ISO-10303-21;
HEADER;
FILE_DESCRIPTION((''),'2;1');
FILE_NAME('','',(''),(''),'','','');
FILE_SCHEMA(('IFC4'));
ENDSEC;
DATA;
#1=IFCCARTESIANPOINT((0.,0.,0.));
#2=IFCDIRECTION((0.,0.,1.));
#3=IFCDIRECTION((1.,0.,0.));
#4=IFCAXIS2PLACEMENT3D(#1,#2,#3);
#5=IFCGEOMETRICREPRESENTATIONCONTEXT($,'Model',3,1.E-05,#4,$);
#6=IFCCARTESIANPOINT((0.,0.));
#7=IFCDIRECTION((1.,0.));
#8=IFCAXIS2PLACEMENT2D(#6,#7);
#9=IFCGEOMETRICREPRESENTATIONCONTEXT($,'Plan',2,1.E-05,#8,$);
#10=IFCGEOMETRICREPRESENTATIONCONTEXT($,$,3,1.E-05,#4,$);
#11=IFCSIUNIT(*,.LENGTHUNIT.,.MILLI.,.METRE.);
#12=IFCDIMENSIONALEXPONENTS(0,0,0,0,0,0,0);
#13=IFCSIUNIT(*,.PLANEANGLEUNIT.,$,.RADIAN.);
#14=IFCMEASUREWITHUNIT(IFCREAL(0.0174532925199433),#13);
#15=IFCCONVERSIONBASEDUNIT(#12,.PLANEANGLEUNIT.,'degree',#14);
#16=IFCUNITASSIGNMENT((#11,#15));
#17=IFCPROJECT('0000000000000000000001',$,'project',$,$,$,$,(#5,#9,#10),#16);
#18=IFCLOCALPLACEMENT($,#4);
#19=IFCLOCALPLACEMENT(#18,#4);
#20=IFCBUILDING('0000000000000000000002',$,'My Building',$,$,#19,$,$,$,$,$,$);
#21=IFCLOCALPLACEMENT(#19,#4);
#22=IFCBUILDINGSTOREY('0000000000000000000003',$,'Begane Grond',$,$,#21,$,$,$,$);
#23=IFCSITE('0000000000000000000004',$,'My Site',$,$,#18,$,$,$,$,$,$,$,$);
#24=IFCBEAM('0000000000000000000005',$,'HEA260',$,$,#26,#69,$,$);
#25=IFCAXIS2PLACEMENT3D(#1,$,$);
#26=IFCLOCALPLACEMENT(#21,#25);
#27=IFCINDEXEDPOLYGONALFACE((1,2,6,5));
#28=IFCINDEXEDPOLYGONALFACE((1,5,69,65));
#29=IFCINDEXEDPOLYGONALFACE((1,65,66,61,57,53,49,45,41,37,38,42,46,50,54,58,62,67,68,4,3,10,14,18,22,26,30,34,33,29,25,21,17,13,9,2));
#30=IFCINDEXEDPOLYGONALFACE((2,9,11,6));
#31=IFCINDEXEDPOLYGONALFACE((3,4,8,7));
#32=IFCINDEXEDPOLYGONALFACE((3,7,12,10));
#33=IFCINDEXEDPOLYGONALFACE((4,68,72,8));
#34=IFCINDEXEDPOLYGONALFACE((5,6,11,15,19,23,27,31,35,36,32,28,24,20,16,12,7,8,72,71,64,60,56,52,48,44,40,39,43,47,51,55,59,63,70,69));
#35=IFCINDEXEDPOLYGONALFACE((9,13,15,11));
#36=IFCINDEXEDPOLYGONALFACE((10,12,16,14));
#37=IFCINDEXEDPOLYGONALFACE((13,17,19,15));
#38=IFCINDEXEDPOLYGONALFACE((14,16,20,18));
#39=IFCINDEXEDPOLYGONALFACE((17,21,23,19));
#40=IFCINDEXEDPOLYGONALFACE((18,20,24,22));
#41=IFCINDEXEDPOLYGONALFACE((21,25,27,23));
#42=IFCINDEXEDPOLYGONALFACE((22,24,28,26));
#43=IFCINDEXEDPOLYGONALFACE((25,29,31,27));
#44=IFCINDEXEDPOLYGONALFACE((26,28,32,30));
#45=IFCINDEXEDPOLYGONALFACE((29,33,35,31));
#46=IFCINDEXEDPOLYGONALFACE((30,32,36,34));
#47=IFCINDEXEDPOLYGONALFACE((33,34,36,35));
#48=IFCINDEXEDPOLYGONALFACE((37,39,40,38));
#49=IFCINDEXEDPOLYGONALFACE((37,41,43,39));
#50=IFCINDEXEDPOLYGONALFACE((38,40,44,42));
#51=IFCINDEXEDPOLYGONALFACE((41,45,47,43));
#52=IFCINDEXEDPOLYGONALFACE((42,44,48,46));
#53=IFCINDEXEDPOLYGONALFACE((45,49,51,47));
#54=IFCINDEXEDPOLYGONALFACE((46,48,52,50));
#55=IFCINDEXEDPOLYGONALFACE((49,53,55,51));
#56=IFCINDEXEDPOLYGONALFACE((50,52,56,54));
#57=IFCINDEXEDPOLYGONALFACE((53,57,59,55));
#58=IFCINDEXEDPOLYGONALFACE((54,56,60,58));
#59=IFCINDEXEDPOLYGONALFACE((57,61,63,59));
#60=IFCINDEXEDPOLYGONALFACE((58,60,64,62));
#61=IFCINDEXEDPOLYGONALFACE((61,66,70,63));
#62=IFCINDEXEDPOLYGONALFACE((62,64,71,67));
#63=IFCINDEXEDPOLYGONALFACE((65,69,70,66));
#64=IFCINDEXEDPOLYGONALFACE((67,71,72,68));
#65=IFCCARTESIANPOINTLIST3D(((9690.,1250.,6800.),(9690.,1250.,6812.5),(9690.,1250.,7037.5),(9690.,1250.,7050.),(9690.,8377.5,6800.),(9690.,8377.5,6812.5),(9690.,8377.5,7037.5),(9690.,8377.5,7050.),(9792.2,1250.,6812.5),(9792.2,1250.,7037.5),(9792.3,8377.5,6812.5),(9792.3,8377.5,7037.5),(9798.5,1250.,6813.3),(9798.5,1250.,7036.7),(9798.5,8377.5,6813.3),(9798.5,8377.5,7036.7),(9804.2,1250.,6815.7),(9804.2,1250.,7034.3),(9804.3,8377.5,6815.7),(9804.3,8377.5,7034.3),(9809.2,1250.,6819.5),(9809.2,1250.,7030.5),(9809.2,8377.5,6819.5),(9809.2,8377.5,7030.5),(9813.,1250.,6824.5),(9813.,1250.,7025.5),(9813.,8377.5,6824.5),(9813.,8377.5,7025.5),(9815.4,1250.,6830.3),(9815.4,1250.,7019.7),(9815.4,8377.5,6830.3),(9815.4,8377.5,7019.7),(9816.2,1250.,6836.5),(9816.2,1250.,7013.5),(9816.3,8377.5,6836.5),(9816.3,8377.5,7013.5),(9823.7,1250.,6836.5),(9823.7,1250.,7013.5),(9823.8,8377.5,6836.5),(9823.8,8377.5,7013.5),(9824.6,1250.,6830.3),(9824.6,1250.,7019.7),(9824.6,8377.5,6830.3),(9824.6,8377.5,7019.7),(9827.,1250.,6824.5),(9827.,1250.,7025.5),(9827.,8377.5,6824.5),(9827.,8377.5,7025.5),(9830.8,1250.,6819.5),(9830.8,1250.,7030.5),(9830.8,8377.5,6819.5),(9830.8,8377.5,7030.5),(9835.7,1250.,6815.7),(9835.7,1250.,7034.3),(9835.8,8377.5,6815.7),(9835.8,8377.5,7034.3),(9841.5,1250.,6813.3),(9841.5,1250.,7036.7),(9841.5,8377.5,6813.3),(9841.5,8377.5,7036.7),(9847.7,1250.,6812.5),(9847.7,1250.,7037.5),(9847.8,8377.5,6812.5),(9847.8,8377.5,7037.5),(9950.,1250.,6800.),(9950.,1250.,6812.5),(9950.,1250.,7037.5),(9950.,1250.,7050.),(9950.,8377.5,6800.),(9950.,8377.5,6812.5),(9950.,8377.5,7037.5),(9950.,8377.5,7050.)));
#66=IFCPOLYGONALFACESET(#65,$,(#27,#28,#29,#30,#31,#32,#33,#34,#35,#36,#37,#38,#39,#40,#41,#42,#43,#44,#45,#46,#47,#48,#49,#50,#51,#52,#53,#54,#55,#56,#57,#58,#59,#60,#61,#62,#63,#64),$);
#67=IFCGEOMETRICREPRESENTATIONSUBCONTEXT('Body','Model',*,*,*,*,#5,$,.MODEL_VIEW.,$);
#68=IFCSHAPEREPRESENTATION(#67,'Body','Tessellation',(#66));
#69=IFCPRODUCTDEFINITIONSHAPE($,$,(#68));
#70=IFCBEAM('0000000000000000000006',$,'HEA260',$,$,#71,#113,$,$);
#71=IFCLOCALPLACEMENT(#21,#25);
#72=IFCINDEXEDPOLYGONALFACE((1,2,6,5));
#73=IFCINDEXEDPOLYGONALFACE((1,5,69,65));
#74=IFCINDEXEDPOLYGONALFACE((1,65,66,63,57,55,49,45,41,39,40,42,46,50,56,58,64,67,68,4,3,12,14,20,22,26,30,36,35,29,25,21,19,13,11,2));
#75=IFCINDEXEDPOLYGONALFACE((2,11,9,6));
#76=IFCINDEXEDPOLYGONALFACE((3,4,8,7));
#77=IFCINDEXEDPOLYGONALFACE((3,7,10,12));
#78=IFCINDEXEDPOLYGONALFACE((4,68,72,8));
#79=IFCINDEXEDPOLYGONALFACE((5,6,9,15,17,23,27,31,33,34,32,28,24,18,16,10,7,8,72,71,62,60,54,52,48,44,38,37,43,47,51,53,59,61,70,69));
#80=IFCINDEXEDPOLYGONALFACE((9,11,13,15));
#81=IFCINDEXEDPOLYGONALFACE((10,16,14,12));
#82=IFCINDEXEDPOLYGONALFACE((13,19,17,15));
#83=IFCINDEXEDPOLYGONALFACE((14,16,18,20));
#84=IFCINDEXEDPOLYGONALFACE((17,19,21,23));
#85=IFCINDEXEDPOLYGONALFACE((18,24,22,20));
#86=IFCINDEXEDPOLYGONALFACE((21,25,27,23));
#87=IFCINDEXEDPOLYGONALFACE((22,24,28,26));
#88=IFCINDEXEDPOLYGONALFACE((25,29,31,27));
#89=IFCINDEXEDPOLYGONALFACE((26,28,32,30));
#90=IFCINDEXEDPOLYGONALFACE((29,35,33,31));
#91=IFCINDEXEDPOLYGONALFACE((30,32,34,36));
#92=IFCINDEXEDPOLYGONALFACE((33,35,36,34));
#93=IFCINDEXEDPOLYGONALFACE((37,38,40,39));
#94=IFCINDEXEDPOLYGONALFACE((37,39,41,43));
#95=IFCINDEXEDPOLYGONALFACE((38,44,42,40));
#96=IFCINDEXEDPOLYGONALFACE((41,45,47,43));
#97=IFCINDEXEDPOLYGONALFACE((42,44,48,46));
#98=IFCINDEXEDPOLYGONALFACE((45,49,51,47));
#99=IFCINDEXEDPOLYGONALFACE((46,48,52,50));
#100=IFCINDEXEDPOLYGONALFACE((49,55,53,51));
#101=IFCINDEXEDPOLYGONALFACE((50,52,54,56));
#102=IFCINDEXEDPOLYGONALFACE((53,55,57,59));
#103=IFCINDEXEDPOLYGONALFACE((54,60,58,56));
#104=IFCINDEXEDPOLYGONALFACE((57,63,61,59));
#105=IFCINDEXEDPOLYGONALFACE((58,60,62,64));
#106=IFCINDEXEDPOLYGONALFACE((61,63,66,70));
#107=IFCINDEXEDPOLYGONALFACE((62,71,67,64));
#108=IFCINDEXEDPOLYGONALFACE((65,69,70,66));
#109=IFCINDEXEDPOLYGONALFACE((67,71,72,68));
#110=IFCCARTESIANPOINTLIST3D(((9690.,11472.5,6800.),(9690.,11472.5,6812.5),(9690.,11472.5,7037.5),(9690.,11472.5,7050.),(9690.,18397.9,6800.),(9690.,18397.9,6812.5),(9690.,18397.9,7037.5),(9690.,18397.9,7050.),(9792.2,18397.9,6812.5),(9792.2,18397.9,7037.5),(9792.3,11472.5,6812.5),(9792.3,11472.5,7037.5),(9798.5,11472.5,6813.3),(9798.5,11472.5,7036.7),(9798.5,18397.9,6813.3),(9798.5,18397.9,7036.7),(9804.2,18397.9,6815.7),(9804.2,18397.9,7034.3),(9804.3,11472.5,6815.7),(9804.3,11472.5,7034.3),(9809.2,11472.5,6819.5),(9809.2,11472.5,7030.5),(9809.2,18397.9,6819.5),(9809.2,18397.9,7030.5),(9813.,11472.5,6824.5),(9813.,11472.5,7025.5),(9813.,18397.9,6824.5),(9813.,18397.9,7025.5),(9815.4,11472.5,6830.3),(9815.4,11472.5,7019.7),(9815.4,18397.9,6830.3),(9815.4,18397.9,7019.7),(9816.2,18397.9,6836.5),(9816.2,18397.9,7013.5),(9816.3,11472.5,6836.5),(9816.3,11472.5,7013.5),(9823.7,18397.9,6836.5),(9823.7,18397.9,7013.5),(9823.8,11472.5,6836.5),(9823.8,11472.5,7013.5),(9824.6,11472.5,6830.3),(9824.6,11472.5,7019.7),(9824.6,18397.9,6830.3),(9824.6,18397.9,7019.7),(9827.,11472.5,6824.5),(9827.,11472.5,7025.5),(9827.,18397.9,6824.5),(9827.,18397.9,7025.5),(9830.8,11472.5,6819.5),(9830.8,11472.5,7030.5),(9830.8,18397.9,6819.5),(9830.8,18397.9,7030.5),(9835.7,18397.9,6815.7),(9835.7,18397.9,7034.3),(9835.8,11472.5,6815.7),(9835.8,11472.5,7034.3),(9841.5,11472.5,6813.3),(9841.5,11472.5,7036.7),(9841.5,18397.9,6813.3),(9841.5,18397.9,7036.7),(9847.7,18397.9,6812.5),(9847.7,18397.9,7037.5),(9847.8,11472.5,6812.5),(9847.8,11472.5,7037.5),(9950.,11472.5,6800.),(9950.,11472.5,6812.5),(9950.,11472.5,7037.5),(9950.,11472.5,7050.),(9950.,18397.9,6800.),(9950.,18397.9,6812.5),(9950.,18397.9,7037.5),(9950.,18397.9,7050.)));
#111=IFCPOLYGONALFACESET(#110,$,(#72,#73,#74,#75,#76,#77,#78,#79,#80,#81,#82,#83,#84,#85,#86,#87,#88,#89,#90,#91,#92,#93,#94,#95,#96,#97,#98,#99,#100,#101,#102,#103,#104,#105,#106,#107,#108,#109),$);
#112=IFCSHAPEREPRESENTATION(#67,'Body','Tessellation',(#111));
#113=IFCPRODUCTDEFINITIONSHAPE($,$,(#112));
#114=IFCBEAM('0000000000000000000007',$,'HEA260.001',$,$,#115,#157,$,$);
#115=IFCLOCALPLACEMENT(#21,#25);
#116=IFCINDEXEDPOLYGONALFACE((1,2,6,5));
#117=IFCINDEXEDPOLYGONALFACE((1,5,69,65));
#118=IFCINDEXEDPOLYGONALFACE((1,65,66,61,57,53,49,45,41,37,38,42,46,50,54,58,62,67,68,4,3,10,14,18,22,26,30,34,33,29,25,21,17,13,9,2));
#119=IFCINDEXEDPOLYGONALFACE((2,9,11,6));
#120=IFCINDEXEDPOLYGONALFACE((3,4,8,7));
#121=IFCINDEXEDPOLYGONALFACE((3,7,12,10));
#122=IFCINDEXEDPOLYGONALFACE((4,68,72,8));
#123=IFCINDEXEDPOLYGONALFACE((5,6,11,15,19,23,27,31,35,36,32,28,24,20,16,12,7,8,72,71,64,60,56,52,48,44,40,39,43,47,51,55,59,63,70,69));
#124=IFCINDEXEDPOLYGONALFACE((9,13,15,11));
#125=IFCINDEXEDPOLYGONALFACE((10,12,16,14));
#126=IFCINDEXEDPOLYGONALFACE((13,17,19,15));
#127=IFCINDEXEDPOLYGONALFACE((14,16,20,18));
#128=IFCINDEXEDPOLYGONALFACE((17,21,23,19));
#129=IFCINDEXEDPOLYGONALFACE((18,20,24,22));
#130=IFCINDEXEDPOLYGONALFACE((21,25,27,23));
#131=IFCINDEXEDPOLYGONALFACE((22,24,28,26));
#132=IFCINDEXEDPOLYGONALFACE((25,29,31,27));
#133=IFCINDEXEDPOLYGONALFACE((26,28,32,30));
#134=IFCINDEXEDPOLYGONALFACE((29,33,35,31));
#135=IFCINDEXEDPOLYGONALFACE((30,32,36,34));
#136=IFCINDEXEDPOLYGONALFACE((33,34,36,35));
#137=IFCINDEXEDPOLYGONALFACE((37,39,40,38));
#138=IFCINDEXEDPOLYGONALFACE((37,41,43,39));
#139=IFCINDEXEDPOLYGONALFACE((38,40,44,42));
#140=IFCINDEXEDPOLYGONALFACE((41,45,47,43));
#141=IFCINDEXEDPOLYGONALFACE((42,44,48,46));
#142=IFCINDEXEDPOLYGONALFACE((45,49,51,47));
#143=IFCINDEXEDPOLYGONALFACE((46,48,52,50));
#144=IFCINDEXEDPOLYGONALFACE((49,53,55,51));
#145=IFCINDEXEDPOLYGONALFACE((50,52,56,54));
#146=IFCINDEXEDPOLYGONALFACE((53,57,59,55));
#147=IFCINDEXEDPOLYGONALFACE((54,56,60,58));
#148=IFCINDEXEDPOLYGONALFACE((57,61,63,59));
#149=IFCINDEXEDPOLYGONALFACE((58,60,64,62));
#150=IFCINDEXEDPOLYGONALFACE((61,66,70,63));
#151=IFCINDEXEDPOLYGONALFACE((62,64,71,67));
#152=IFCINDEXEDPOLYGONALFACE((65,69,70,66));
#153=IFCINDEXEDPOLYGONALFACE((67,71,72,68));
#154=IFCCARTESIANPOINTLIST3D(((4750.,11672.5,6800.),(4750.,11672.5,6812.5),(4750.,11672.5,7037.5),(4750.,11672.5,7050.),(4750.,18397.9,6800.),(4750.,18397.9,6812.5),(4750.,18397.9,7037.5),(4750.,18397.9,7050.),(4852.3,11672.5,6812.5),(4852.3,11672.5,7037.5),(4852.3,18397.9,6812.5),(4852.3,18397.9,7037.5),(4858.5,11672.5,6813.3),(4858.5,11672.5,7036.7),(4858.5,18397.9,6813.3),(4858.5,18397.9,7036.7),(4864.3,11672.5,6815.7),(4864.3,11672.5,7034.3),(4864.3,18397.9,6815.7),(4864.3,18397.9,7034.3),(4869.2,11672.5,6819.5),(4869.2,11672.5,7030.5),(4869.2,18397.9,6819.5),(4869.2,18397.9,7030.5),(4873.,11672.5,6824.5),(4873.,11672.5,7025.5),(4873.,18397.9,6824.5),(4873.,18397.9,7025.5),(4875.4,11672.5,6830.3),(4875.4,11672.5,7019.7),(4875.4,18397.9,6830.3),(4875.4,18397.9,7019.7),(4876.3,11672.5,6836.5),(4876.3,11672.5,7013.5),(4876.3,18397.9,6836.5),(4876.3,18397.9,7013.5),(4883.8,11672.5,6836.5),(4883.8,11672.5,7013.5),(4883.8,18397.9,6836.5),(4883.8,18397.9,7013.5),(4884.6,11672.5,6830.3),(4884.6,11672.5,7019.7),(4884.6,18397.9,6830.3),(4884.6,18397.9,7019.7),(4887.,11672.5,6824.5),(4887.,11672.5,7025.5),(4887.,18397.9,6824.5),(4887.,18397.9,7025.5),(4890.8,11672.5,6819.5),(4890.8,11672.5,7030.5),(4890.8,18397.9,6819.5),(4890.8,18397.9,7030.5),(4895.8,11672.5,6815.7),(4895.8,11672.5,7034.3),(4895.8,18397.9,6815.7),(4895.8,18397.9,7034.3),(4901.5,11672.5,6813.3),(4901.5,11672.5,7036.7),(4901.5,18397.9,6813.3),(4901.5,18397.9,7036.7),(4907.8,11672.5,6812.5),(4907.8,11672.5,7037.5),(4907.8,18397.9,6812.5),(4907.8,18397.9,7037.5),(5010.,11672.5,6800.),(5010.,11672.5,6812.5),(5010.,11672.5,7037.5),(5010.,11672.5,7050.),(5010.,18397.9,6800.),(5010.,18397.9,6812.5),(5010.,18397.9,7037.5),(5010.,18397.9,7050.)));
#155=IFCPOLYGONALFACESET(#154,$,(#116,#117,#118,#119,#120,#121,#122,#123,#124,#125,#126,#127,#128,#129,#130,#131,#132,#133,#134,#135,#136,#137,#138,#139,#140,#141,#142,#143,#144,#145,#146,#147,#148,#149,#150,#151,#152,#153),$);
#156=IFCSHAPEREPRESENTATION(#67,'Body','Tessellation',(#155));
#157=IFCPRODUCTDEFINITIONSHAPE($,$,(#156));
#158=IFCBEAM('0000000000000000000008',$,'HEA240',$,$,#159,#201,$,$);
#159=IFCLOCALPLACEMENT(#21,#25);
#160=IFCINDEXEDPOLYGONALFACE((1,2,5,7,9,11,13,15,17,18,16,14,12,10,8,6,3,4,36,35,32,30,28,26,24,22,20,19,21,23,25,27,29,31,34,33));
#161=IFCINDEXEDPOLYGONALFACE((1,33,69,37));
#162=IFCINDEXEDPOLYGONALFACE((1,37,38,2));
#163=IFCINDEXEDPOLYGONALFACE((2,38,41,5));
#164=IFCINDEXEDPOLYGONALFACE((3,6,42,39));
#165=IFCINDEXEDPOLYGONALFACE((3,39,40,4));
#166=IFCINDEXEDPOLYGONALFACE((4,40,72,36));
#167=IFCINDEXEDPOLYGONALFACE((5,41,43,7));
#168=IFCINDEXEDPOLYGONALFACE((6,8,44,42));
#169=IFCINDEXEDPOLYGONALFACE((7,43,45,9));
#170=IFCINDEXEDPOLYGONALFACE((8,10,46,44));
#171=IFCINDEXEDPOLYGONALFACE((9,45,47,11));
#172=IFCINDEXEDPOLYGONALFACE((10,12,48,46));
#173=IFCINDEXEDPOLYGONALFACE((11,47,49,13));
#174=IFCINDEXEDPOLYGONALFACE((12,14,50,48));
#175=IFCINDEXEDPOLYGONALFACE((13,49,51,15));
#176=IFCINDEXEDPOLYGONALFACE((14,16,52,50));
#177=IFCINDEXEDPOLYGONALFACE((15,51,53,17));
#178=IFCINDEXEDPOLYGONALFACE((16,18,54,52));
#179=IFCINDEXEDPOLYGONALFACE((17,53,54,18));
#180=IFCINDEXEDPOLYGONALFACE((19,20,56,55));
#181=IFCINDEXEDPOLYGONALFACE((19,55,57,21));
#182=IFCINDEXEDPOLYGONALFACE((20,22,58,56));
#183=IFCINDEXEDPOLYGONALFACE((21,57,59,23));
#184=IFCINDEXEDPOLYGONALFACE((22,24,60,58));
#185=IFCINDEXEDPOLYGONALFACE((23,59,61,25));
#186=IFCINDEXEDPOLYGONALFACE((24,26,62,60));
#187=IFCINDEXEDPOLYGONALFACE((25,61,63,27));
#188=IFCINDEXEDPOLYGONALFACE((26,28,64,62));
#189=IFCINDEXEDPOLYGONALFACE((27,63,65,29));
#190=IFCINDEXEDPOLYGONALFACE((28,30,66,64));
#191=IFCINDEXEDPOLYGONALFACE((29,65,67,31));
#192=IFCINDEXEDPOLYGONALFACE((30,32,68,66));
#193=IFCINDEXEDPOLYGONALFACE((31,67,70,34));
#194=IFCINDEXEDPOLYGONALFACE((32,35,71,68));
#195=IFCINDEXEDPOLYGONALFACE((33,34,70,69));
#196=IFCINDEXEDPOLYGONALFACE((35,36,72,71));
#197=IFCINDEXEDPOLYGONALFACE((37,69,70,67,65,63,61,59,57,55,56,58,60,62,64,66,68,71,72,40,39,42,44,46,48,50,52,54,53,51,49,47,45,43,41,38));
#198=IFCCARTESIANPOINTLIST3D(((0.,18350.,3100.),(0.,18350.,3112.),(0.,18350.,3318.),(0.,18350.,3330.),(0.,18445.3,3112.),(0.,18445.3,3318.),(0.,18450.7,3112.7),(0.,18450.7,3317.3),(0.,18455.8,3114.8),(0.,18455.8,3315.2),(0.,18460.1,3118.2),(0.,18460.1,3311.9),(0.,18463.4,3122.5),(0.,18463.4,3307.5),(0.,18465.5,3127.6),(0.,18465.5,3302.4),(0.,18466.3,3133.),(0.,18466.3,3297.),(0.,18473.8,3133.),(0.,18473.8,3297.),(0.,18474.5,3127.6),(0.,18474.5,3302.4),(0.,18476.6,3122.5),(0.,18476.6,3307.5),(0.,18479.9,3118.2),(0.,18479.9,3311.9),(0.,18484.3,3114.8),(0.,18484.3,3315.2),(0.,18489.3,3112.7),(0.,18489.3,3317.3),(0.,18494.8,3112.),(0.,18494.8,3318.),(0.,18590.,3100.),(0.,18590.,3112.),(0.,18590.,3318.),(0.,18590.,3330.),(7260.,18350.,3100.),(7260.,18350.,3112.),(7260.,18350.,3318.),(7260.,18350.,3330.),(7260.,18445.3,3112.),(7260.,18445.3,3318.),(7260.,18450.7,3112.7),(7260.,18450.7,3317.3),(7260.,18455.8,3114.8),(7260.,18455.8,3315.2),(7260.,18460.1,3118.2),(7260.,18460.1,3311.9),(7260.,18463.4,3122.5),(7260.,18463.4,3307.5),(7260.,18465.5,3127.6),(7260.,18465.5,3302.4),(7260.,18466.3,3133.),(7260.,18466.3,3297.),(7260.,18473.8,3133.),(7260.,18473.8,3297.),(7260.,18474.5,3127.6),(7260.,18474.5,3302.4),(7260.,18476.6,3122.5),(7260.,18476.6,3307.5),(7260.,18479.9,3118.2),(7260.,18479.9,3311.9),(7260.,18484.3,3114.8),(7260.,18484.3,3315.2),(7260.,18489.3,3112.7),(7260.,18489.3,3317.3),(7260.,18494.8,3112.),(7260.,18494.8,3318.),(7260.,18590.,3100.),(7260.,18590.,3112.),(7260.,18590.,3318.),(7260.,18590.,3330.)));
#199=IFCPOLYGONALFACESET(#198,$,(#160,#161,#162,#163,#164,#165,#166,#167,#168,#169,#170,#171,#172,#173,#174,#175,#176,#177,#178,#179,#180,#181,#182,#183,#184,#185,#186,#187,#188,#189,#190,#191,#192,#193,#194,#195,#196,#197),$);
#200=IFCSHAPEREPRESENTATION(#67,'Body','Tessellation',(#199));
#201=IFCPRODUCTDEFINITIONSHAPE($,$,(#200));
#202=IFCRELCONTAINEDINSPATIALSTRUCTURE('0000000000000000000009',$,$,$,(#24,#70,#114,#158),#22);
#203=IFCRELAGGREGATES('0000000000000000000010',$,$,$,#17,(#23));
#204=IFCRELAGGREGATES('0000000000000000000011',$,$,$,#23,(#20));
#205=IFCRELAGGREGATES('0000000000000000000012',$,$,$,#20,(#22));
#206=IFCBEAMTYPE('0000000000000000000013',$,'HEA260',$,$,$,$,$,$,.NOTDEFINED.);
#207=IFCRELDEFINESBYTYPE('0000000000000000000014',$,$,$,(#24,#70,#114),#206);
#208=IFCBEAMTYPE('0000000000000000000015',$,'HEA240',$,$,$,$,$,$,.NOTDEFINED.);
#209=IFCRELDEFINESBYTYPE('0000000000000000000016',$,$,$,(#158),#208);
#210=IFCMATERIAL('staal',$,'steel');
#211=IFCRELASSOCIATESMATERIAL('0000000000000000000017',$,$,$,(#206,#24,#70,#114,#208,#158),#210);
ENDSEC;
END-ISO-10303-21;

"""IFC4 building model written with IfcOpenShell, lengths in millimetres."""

from ifc_helpers import new_model, entity, si_unit, converted_unit, frame, origin_with_axes, origin_2d_with_axis, place, context, subcontext, project, spatial, i_section, extrude, material, material_profile, profile_set, profile_usage, type_object, element, save


model = new_model("IFC4")

# Units and contexts
model_context = context("Model", 3, precision=1e-05, world=origin_with_axes())
plan_context = context("Plan", 2, precision=1e-05, world=origin_2d_with_axis())
context_of_model = context(None, 3, precision=1e-05, world=origin_with_axes())
body_context = subcontext(model_context, "Body", "Model", "MODEL_VIEW")
ifc_project = project(units=[si_unit("LENGTHUNIT", "METRE", prefix="MILLI"), converted_unit("PLANEANGLEUNIT", "degree", entity("IfcReal", 0.0174532925199433), si_unit("PLANEANGLEUNIT", "RADIAN"), dimensions=[0, 0, 0, 0, 0, 0, 0])], contexts=[model_context, plan_context, context_of_model])

# Site, building, storey
site_placement = place(None, origin_with_axes())
site = spatial("IfcSite", under=ifc_project, at=site_placement, Name="My Site")
building_placement = place(site_placement, origin_with_axes())
building = spatial("IfcBuilding", under=site, at=building_placement, Name="My Building")
storey_placement = place(building_placement, origin_with_axes())
storey = spatial("IfcBuildingStorey", under=building, at=storey_placement, Name="Begane Grond")

# Shared definitions
ifc_material = material(Name="staal", Category="steel")

# Beams
ifc_material_profile_1 = material_profile(ifc_material, i_section(OverallWidth=260.0, OverallDepth=250.0, WebThickness=7.5, FlangeThickness=12.5, FilletRadius=24.0))
ifc_profile_set_1 = profile_set([ifc_material_profile_1], Name="HEA260")
beam_type_1 = type_object("IfcBeamType", Name="HEA260", PredefinedType="NOTDEFINED", material=ifc_profile_set_1)
ifc_profile_usage_1 = profile_usage(ifc_profile_set_1)
beam_1_placement = place(storey_placement, frame((9820.0, 1250.0, 6925.0), z_axis=(0.0, 1.0, 0.0), x_axis=(-1.0, 0.0, 0.0)))
element("IfcBeam", 1, at=beam_1_placement, inside=storey, type_object=beam_type_1, material=ifc_profile_usage_1, Name="HEA260", context=body_context, shape_type="SweptSolid", body=[
    extrude(i_section(OverallWidth=260.0, OverallDepth=250.0, WebThickness=7.5, FlangeThickness=12.5, FilletRadius=24.0), origin_with_axes(), (0.0, 0.0, 1.0), 7127.5),
])
ifc_profile_usage_2 = profile_usage(ifc_profile_set_1)
beam_2_placement = place(storey_placement, frame((9820.0, 18397.9, 6925.0), z_axis=(0.0, -1.0, 0.0), x_axis=(1.0, 0.0, 0.0)))
element("IfcBeam", 2, at=beam_2_placement, inside=storey, type_object=beam_type_1, material=ifc_profile_usage_2, Name="HEA260", context=body_context, shape_type="SweptSolid", body=[
    extrude(i_section(OverallWidth=260.0, OverallDepth=250.0, WebThickness=7.5, FlangeThickness=12.5, FilletRadius=24.0), origin_with_axes(), (0.0, 0.0, 1.0), 6925.4),
])
ifc_profile_usage_3 = profile_usage(ifc_profile_set_1)
beam_3_placement = place(storey_placement, frame((4880.0, 18397.9, 6925.0), z_axis=(0.0, -1.0, 0.0), x_axis=(1.0, 0.0, 0.0)))
element("IfcBeam", 3, at=beam_3_placement, inside=storey, type_object=beam_type_1, material=ifc_profile_usage_3, Name="HEA260.001", context=body_context, shape_type="SweptSolid", body=[
    extrude(i_section(OverallWidth=260.0, OverallDepth=250.0, WebThickness=7.5, FlangeThickness=12.5, FilletRadius=24.0), origin_with_axes(), (0.0, 0.0, 1.0), 6725.4),
])
ifc_material_profile_2 = material_profile(ifc_material, i_section(OverallWidth=240.0, OverallDepth=230.0, WebThickness=7.5, FlangeThickness=12.0, FilletRadius=21.0))
ifc_profile_set_2 = profile_set([ifc_material_profile_2], Name="HEA240")
ifc_profile_usage_4 = profile_usage(ifc_profile_set_2, cardinal=5)
beam_type_2 = type_object("IfcBeamType", Name="HEA240", PredefinedType="NOTDEFINED", material=ifc_profile_set_2)
beam_4_placement = place(storey_placement, frame((0.0, 18470.0, 3215.0), z_axis=(1.0, 0.0, 0.0), x_axis=(0.0, 1.0, 0.0)))
element("IfcBeam", 4, at=beam_4_placement, inside=storey, type_object=beam_type_2, material=ifc_profile_usage_4, Name="HEA240", context=body_context, shape_type="SweptSolid", body=[
    extrude(i_section(OverallWidth=240.0, OverallDepth=230.0, WebThickness=7.5, FlangeThickness=12.0, FilletRadius=21.0), origin_with_axes(), (0.0, 0.0, 1.0), 7260.0),
])

save(model, "model.ifc")
